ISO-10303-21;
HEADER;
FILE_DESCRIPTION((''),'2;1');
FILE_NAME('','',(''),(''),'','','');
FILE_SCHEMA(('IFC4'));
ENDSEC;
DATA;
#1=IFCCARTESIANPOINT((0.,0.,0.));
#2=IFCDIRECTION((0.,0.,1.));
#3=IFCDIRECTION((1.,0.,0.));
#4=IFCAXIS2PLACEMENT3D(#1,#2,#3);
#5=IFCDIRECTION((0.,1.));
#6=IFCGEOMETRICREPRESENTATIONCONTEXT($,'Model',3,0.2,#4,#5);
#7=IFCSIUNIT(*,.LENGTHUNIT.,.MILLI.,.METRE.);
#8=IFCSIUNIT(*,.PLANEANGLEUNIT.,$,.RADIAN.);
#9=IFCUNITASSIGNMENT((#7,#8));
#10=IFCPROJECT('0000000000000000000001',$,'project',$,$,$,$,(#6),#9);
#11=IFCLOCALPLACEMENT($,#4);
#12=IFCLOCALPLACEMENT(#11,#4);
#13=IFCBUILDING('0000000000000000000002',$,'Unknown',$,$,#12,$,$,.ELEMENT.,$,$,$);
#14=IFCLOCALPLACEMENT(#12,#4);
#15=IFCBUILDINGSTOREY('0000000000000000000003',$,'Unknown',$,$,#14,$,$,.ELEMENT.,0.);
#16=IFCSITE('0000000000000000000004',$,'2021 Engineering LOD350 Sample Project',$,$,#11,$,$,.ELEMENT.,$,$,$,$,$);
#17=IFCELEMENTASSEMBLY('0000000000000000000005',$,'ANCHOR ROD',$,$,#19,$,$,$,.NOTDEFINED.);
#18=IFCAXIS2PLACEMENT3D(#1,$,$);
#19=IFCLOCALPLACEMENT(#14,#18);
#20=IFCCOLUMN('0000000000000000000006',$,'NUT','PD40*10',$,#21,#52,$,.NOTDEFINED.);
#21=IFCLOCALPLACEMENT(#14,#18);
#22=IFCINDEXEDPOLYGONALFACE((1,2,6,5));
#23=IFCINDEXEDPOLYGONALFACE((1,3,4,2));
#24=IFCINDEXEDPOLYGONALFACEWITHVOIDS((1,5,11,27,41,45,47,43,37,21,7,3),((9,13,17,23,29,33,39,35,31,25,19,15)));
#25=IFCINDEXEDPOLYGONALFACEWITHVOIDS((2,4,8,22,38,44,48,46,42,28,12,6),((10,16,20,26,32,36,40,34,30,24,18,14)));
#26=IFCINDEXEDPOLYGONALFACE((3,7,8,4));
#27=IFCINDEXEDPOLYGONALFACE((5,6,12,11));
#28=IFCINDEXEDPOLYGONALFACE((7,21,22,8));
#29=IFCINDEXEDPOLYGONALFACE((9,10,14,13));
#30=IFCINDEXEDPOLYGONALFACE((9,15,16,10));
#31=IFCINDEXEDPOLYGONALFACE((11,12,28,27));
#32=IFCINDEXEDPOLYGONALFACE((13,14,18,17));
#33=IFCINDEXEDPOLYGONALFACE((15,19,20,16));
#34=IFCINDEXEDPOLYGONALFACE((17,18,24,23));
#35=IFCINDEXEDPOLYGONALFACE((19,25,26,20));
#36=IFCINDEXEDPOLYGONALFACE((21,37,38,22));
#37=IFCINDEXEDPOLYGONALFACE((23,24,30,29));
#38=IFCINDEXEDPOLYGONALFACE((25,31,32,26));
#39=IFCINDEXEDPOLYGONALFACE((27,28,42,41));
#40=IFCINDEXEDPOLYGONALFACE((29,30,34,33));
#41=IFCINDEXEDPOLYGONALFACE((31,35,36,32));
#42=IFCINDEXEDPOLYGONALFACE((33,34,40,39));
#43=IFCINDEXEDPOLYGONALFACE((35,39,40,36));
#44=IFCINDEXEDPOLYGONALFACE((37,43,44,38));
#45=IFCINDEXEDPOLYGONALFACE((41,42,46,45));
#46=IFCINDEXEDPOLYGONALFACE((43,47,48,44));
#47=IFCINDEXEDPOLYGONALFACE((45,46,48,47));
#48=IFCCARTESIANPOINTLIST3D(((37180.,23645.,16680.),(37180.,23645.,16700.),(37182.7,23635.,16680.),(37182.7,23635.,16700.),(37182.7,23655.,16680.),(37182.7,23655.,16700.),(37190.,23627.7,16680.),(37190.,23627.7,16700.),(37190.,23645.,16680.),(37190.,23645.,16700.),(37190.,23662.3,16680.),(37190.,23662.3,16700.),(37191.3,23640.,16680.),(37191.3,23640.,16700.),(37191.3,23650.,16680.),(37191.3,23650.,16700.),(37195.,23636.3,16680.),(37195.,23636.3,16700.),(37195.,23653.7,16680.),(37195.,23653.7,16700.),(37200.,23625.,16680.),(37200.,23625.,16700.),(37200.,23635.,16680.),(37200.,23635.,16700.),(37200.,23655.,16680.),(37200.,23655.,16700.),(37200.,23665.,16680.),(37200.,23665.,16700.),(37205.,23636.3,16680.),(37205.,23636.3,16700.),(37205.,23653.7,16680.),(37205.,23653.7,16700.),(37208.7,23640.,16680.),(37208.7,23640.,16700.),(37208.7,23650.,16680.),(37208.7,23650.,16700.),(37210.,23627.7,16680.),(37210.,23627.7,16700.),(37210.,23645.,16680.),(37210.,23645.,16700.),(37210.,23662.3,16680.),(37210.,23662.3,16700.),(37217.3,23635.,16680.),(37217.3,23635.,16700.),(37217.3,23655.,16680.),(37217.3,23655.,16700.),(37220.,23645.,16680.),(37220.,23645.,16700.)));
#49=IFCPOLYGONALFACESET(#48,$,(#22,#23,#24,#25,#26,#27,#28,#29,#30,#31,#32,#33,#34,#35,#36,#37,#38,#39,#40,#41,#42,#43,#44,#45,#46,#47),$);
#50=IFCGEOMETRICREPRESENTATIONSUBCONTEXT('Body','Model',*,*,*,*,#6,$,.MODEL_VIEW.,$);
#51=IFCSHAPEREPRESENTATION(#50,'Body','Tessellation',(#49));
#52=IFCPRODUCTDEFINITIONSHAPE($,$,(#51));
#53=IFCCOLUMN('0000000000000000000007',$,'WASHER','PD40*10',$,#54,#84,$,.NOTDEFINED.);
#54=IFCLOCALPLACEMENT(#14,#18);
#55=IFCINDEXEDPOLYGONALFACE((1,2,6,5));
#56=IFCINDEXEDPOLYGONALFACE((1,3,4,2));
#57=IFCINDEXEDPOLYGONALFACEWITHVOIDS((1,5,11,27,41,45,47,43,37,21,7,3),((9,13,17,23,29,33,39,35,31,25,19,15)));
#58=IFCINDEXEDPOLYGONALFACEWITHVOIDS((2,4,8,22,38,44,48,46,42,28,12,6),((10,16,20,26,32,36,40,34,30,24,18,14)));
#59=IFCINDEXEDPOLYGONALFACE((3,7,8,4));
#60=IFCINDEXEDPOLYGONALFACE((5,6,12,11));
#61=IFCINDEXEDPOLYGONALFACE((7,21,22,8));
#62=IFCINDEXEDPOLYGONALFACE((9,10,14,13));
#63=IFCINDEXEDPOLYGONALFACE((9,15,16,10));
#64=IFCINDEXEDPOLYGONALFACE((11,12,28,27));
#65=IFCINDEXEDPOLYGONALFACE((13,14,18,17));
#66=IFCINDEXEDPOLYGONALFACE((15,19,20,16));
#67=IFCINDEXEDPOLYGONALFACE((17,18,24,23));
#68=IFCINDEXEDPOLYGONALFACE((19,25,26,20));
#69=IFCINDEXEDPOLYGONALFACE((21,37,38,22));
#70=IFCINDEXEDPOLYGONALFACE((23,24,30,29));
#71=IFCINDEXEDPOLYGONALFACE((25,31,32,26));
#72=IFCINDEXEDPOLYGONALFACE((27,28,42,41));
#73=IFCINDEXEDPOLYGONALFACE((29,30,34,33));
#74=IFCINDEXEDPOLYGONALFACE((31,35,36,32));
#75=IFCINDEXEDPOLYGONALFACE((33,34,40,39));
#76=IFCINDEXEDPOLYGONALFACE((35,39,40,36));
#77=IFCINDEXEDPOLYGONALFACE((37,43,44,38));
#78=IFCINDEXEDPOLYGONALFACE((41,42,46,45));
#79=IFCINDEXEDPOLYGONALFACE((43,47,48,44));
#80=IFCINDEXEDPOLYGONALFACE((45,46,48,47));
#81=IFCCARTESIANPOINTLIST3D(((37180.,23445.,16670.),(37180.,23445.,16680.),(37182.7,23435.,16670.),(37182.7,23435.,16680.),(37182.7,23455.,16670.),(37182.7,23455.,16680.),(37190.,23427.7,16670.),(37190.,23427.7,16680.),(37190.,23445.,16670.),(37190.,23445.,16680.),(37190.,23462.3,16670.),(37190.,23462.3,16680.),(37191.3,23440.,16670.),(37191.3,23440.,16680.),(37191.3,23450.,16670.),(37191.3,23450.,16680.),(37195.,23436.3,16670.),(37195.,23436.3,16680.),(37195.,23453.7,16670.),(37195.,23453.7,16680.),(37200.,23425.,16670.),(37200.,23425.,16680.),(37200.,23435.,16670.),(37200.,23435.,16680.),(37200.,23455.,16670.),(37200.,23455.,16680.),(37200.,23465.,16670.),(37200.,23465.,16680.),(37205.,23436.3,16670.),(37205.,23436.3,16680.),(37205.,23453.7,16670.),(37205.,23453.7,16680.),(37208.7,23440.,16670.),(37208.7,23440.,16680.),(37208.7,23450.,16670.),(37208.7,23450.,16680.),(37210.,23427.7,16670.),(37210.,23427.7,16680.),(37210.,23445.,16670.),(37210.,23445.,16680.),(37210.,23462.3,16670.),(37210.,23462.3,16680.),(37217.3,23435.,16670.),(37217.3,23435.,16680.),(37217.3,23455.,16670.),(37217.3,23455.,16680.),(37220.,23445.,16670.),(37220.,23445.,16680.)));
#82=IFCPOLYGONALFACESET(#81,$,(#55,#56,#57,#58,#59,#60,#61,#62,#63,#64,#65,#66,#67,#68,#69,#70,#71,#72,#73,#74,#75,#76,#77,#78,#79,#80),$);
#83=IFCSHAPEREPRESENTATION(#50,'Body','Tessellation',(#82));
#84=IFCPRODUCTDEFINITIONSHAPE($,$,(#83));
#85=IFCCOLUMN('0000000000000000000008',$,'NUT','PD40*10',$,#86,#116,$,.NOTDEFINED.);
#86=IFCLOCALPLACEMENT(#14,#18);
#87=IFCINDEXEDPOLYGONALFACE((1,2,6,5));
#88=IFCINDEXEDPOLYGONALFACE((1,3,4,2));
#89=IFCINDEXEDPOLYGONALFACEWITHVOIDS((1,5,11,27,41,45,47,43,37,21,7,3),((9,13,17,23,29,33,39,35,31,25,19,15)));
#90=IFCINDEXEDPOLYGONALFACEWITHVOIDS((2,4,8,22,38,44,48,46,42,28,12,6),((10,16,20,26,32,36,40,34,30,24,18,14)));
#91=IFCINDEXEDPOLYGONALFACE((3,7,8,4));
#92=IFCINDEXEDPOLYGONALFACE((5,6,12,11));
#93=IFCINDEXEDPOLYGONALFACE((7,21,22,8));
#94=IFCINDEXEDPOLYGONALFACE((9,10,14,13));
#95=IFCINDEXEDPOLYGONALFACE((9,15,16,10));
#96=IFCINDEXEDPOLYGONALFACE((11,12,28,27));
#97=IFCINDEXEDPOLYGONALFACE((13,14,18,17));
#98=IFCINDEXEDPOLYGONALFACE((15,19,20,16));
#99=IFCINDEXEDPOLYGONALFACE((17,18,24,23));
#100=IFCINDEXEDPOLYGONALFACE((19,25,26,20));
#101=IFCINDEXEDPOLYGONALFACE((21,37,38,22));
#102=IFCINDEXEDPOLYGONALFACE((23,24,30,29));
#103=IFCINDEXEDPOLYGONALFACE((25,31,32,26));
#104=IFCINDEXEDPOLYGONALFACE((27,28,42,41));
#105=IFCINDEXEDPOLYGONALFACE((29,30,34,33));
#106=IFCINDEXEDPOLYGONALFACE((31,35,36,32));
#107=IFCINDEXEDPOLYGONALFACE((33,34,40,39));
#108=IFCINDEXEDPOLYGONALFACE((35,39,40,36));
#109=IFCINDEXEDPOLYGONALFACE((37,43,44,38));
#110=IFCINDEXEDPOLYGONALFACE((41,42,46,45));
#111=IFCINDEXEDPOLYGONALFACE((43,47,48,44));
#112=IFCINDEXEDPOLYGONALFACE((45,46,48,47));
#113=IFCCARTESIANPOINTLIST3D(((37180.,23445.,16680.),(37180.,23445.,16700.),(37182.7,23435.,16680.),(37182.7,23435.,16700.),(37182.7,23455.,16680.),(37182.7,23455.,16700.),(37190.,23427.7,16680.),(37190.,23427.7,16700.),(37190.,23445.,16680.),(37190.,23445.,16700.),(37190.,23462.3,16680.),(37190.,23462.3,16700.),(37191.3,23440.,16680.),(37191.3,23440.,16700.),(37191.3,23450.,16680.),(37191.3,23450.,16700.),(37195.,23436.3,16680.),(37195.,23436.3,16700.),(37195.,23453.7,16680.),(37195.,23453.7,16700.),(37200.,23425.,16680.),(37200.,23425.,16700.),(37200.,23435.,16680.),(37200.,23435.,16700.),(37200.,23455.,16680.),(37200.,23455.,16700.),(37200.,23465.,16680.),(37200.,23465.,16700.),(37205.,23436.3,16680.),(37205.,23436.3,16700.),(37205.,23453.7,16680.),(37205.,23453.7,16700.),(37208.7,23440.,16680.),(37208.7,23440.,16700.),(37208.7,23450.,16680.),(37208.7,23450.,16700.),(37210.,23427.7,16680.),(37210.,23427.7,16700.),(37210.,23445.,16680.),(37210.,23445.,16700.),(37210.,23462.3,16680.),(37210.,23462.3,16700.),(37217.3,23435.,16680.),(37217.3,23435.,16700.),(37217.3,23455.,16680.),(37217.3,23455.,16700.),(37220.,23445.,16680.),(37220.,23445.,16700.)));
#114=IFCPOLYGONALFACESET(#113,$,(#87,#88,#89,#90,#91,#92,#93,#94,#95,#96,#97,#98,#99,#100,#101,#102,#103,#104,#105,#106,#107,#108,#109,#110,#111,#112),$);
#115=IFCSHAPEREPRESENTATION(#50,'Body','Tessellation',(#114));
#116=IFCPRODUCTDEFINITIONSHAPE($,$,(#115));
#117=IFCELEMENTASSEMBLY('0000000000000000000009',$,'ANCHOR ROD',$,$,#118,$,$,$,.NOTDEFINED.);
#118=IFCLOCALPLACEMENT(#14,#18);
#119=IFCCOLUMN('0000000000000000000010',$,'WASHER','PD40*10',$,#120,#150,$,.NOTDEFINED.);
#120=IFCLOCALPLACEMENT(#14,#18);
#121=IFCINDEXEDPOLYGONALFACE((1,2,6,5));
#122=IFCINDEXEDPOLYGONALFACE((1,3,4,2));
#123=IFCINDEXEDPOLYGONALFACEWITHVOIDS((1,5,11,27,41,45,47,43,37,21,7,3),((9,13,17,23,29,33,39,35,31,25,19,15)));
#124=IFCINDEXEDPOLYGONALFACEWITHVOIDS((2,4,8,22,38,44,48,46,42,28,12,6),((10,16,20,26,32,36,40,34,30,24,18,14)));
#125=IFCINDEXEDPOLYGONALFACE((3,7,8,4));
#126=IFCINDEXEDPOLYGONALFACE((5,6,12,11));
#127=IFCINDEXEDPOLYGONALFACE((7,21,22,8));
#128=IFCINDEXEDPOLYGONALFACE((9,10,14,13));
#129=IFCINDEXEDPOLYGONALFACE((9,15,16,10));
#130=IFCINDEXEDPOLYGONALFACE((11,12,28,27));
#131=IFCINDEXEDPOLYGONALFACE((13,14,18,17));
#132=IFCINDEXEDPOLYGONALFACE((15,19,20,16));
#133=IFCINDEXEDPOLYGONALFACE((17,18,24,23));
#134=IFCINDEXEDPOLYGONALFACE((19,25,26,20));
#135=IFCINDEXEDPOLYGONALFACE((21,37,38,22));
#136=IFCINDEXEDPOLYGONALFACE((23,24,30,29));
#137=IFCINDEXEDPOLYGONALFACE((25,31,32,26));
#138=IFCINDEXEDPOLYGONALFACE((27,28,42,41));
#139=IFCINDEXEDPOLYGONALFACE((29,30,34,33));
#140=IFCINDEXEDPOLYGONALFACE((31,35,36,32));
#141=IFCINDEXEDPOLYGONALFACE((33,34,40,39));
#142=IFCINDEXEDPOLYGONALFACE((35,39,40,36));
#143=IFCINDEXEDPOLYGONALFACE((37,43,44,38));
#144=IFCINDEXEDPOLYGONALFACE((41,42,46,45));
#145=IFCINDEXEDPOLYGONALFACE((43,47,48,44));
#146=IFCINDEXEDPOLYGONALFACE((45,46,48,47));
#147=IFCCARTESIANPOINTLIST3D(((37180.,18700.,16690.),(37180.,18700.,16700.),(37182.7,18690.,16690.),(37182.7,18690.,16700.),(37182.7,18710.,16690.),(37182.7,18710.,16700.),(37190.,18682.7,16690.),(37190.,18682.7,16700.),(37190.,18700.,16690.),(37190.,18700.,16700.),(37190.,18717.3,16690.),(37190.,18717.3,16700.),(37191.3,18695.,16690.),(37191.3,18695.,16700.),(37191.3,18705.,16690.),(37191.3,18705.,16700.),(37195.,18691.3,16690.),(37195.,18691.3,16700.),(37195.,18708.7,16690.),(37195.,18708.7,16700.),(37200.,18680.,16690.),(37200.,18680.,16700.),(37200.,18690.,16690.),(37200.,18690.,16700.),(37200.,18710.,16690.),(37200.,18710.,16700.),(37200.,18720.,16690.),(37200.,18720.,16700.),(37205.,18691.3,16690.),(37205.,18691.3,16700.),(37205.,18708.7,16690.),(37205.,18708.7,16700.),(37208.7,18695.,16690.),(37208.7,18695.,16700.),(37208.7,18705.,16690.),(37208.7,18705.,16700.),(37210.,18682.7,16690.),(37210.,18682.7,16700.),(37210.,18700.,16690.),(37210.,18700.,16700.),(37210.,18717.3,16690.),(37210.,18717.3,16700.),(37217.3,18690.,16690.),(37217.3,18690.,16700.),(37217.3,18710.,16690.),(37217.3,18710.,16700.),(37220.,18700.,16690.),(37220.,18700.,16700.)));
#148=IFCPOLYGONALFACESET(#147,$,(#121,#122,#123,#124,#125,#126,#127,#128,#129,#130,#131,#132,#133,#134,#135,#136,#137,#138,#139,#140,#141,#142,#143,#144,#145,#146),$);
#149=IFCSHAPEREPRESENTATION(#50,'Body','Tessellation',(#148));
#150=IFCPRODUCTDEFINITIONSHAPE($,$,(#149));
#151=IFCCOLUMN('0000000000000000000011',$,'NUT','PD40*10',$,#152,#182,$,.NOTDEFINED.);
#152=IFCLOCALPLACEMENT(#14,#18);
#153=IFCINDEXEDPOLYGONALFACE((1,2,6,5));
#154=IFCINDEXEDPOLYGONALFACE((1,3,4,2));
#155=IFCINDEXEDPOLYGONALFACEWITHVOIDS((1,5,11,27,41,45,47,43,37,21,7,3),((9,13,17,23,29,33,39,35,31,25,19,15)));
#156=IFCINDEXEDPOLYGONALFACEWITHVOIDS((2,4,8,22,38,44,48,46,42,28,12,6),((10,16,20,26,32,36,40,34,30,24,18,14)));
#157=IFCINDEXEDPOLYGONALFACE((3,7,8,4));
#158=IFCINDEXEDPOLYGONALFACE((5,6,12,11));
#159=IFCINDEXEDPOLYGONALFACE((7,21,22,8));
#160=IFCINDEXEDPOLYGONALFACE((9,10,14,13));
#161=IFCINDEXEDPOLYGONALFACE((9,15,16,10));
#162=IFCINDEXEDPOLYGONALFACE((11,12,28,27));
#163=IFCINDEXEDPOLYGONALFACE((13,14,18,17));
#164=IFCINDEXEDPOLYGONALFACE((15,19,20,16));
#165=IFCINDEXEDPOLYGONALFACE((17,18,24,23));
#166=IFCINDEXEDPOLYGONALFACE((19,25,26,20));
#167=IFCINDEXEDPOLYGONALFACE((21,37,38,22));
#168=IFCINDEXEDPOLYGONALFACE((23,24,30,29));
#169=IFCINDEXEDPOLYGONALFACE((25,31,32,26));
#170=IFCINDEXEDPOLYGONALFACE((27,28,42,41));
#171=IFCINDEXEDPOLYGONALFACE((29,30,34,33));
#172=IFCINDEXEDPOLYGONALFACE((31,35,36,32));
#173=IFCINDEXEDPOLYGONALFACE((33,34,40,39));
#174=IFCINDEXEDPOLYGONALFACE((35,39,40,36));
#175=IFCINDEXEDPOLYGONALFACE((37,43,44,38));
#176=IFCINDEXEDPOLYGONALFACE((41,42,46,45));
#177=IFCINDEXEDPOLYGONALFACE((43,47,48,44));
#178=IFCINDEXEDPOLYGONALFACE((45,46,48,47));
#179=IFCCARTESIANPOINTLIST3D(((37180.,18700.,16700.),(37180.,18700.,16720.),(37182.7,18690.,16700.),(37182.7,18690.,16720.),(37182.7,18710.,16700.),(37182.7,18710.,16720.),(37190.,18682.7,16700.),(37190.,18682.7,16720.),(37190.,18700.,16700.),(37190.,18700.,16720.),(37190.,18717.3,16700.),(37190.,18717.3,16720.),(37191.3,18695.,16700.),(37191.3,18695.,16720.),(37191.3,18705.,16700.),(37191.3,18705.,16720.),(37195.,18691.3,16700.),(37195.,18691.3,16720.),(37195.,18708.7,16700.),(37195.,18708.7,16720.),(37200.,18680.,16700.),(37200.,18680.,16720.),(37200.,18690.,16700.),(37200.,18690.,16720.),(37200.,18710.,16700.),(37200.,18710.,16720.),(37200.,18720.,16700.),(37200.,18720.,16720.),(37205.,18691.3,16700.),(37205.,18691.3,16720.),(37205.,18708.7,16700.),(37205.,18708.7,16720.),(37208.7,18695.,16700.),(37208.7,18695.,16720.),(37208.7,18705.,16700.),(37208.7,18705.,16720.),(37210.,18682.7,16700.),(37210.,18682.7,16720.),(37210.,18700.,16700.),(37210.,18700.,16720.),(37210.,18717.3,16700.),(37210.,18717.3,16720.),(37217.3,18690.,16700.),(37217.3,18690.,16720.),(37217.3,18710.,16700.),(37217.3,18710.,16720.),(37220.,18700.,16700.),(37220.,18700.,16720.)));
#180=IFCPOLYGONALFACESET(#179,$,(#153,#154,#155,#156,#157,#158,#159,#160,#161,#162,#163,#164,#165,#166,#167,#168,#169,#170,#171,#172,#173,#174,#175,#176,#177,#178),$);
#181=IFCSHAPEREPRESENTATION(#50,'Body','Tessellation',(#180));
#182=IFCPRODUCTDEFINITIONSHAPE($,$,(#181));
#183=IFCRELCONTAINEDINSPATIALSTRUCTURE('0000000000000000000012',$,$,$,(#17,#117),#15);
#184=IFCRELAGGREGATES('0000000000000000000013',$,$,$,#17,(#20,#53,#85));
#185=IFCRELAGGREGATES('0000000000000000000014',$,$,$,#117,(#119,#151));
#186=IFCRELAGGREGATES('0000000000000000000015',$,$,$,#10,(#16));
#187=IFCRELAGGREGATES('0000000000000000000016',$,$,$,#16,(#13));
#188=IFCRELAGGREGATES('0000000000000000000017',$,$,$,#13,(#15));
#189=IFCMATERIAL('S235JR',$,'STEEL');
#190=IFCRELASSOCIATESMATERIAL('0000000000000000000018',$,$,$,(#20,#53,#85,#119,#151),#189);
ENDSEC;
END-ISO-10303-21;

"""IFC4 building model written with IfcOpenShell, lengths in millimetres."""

from ifc_helpers import new_model, si_unit, direction, frame, origin_with_axes, place, context, subcontext, project, spatial, line, indexed_curve, outline, extrude, material, element, aggregate, save


model = new_model("IFC4")

# Units and contexts
model_context = context("Model", 3, precision=0.2, world=origin_with_axes(), true_north=direction((0.0, 1.0)))
body_context = subcontext(model_context, "Body", "Model", "MODEL_VIEW")
ifc_project = project(units=[si_unit("LENGTHUNIT", "METRE", prefix="MILLI"), si_unit("PLANEANGLEUNIT", "RADIAN")], contexts=[model_context])

# Site, building, storey
site_placement = place(None, origin_with_axes())
site = spatial("IfcSite", under=ifc_project, at=site_placement, Name="2021 Engineering LOD350 Sample Project", CompositionType="ELEMENT")
building_placement = place(site_placement, origin_with_axes())
building = spatial("IfcBuilding", under=site, at=building_placement, Name="Unknown", CompositionType="ELEMENT")
storey_placement = place(building_placement, origin_with_axes())
storey = spatial("IfcBuildingStorey", under=building, at=storey_placement, Name="Unknown", CompositionType="ELEMENT", Elevation=0.0)

# Shared definitions
ifc_material_1 = material(Name="S235JR", Category="STEEL")

# Element assemblies, columns
assembly_1_placement = place(storey_placement, frame((37500.0, 23645.0, 16710.0), z_axis=(1.0, 0.0, 0.0), x_axis=(0.0, 0.0, -1.0)))
assembly_1 = element("IfcElementAssembly", 1, at=assembly_1_placement, inside=storey, Name="ANCHOR ROD", PredefinedType="NOTDEFINED")
column_1_placement = place(assembly_1_placement, frame((10.0, 0.0, -300.0), z_axis=(0.0, 0.0, -1.0), x_axis=(1.0, 0.0, 0.0)))
column_1 = element("IfcColumn", 2, at=column_1_placement, material=ifc_material_1, Name="NUT", Description="PD40*10", PredefinedType="NOTDEFINED", context=body_context, shape_type="SolidModel", body=[
    extrude(outline(indexed_curve([(20.0, 0.0), (17.3, 10.0), (10.0, 17.3), (0.0, 20.0), (-10.0, 17.3), (-17.3, 10.0), (-20.0, 0.0), (-17.3, -10.0), (-10.0, -17.3), (0.0, -20.0), (10.0, -17.3), (17.3, -10.0)], segments=[line(1, 2, 3, 4, 5, 6, 7, 8, 9, 10, 11, 12, 1)]), holes=[indexed_curve([(10.0, 0.0), (8.7, -5.0), (5.0, -8.7), (0.0, -10.0), (-5.0, -8.7), (-8.7, -5.0), (-10.0, 0.0), (-8.7, 5.0), (-5.0, 8.7), (0.0, 10.0), (5.0, 8.7), (8.7, 5.0)], segments=[line(1, 2, 3, 4, 5, 6, 7, 8, 9, 10, 11, 12, 1)])]), frame((0.0, 0.0, 0.0), z_axis=(-1.0, 0.0, 0.0), x_axis=(0.0, 0.0, 1.0)), (0.0, 0.0, -1.0), 20.0),
])
column_2_placement = place(assembly_1_placement, frame((30.0, -200.0, -300.0), z_axis=(0.0, 0.0, -1.0), x_axis=(1.0, 0.0, 0.0)))
column_2 = element("IfcColumn", 3, at=column_2_placement, material=ifc_material_1, Name="WASHER", Description="PD40*10", PredefinedType="NOTDEFINED", context=body_context, shape_type="SolidModel", body=[
    extrude(outline(indexed_curve([(20.0, 0.0), (17.3, 10.0), (10.0, 17.3), (0.0, 20.0), (-10.0, 17.3), (-17.3, 10.0), (-20.0, 0.0), (-17.3, -10.0), (-10.0, -17.3), (0.0, -20.0), (10.0, -17.3), (17.3, -10.0)], segments=[line(1, 2, 3, 4, 5, 6, 7, 8, 9, 10, 11, 12, 1)]), holes=[indexed_curve([(10.0, 0.0), (8.7, -5.0), (5.0, -8.7), (0.0, -10.0), (-5.0, -8.7), (-8.7, -5.0), (-10.0, 0.0), (-8.7, 5.0), (-5.0, 8.7), (0.0, 10.0), (5.0, 8.7), (8.7, 5.0)], segments=[line(1, 2, 3, 4, 5, 6, 7, 8, 9, 10, 11, 12, 1)])]), frame((0.0, 0.0, 0.0), z_axis=(-1.0, 0.0, 0.0), x_axis=(0.0, 0.0, 1.0)), (0.0, 0.0, -1.0), 10.0),
])
column_3_placement = place(assembly_1_placement, frame((10.0, -200.0, -300.0), z_axis=(0.0, 0.0, -1.0), x_axis=(1.0, 0.0, 0.0)))
column_3 = element("IfcColumn", 4, at=column_3_placement, material=ifc_material_1, Name="NUT", Description="PD40*10", PredefinedType="NOTDEFINED", context=body_context, shape_type="SolidModel", body=[
    extrude(outline(indexed_curve([(20.0, 0.0), (17.3, 10.0), (10.0, 17.3), (0.0, 20.0), (-10.0, 17.3), (-17.3, 10.0), (-20.0, 0.0), (-17.3, -10.0), (-10.0, -17.3), (0.0, -20.0), (10.0, -17.3), (17.3, -10.0)], segments=[line(1, 2, 3, 4, 5, 6, 7, 8, 9, 10, 11, 12, 1)]), holes=[indexed_curve([(10.0, 0.0), (8.7, -5.0), (5.0, -8.7), (0.0, -10.0), (-5.0, -8.7), (-8.7, -5.0), (-10.0, 0.0), (-8.7, 5.0), (-5.0, 8.7), (0.0, 10.0), (5.0, 8.7), (8.7, 5.0)], segments=[line(1, 2, 3, 4, 5, 6, 7, 8, 9, 10, 11, 12, 1)])]), frame((0.0, 0.0, 0.0), z_axis=(-1.0, 0.0, 0.0), x_axis=(0.0, 0.0, 1.0)), (0.0, 0.0, -1.0), 20.0),
])
aggregate(assembly_1, [column_1, column_2, column_3])
assembly_2_placement = place(storey_placement, frame((37500.0, 18700.0, 16730.0), z_axis=(1.0, 0.0, 0.0), x_axis=(0.0, 0.0, -1.0)))
assembly_2 = element("IfcElementAssembly", 5, at=assembly_2_placement, inside=storey, Name="ANCHOR ROD", PredefinedType="NOTDEFINED")
column_4_placement = place(assembly_2_placement, frame((30.0, 0.0, -300.0), z_axis=(0.0, 0.0, -1.0), x_axis=(1.0, 0.0, 0.0)))
column_4 = element("IfcColumn", 6, at=column_4_placement, material=ifc_material_1, Name="WASHER", Description="PD40*10", PredefinedType="NOTDEFINED", context=body_context, shape_type="SolidModel", body=[
    extrude(outline(indexed_curve([(20.0, 0.0), (17.3, 10.0), (10.0, 17.3), (0.0, 20.0), (-10.0, 17.3), (-17.3, 10.0), (-20.0, 0.0), (-17.3, -10.0), (-10.0, -17.3), (0.0, -20.0), (10.0, -17.3), (17.3, -10.0)], segments=[line(1, 2, 3, 4, 5, 6, 7, 8, 9, 10, 11, 12, 1)]), holes=[indexed_curve([(10.0, 0.0), (8.7, -5.0), (5.0, -8.7), (0.0, -10.0), (-5.0, -8.7), (-8.7, -5.0), (-10.0, 0.0), (-8.7, 5.0), (-5.0, 8.7), (0.0, 10.0), (5.0, 8.7), (8.7, 5.0)], segments=[line(1, 2, 3, 4, 5, 6, 7, 8, 9, 10, 11, 12, 1)])]), frame((0.0, 0.0, 0.0), z_axis=(-1.0, 0.0, 0.0), x_axis=(0.0, 0.0, 1.0)), (0.0, 0.0, -1.0), 10.0),
])
column_5_placement = place(assembly_2_placement, frame((10.0, 0.0, -300.0), z_axis=(0.0, 0.0, -1.0), x_axis=(1.0, 0.0, 0.0)))
column_5 = element("IfcColumn", 7, at=column_5_placement, material=ifc_material_1, Name="NUT", Description="PD40*10", PredefinedType="NOTDEFINED", context=body_context, shape_type="SolidModel", body=[
    extrude(outline(indexed_curve([(20.0, 0.0), (17.3, 10.0), (10.0, 17.3), (0.0, 20.0), (-10.0, 17.3), (-17.3, 10.0), (-20.0, 0.0), (-17.3, -10.0), (-10.0, -17.3), (0.0, -20.0), (10.0, -17.3), (17.3, -10.0)], segments=[line(1, 2, 3, 4, 5, 6, 7, 8, 9, 10, 11, 12, 1)]), holes=[indexed_curve([(10.0, 0.0), (8.7, -5.0), (5.0, -8.7), (0.0, -10.0), (-5.0, -8.7), (-8.7, -5.0), (-10.0, 0.0), (-8.7, 5.0), (-5.0, 8.7), (0.0, 10.0), (5.0, 8.7), (8.7, 5.0)], segments=[line(1, 2, 3, 4, 5, 6, 7, 8, 9, 10, 11, 12, 1)])]), frame((0.0, 0.0, 0.0), z_axis=(-1.0, 0.0, 0.0), x_axis=(0.0, 0.0, 1.0)), (0.0, 0.0, -1.0), 20.0),
])

aggregate(assembly_2, [column_4, column_5])

save(model, "model.ifc")
